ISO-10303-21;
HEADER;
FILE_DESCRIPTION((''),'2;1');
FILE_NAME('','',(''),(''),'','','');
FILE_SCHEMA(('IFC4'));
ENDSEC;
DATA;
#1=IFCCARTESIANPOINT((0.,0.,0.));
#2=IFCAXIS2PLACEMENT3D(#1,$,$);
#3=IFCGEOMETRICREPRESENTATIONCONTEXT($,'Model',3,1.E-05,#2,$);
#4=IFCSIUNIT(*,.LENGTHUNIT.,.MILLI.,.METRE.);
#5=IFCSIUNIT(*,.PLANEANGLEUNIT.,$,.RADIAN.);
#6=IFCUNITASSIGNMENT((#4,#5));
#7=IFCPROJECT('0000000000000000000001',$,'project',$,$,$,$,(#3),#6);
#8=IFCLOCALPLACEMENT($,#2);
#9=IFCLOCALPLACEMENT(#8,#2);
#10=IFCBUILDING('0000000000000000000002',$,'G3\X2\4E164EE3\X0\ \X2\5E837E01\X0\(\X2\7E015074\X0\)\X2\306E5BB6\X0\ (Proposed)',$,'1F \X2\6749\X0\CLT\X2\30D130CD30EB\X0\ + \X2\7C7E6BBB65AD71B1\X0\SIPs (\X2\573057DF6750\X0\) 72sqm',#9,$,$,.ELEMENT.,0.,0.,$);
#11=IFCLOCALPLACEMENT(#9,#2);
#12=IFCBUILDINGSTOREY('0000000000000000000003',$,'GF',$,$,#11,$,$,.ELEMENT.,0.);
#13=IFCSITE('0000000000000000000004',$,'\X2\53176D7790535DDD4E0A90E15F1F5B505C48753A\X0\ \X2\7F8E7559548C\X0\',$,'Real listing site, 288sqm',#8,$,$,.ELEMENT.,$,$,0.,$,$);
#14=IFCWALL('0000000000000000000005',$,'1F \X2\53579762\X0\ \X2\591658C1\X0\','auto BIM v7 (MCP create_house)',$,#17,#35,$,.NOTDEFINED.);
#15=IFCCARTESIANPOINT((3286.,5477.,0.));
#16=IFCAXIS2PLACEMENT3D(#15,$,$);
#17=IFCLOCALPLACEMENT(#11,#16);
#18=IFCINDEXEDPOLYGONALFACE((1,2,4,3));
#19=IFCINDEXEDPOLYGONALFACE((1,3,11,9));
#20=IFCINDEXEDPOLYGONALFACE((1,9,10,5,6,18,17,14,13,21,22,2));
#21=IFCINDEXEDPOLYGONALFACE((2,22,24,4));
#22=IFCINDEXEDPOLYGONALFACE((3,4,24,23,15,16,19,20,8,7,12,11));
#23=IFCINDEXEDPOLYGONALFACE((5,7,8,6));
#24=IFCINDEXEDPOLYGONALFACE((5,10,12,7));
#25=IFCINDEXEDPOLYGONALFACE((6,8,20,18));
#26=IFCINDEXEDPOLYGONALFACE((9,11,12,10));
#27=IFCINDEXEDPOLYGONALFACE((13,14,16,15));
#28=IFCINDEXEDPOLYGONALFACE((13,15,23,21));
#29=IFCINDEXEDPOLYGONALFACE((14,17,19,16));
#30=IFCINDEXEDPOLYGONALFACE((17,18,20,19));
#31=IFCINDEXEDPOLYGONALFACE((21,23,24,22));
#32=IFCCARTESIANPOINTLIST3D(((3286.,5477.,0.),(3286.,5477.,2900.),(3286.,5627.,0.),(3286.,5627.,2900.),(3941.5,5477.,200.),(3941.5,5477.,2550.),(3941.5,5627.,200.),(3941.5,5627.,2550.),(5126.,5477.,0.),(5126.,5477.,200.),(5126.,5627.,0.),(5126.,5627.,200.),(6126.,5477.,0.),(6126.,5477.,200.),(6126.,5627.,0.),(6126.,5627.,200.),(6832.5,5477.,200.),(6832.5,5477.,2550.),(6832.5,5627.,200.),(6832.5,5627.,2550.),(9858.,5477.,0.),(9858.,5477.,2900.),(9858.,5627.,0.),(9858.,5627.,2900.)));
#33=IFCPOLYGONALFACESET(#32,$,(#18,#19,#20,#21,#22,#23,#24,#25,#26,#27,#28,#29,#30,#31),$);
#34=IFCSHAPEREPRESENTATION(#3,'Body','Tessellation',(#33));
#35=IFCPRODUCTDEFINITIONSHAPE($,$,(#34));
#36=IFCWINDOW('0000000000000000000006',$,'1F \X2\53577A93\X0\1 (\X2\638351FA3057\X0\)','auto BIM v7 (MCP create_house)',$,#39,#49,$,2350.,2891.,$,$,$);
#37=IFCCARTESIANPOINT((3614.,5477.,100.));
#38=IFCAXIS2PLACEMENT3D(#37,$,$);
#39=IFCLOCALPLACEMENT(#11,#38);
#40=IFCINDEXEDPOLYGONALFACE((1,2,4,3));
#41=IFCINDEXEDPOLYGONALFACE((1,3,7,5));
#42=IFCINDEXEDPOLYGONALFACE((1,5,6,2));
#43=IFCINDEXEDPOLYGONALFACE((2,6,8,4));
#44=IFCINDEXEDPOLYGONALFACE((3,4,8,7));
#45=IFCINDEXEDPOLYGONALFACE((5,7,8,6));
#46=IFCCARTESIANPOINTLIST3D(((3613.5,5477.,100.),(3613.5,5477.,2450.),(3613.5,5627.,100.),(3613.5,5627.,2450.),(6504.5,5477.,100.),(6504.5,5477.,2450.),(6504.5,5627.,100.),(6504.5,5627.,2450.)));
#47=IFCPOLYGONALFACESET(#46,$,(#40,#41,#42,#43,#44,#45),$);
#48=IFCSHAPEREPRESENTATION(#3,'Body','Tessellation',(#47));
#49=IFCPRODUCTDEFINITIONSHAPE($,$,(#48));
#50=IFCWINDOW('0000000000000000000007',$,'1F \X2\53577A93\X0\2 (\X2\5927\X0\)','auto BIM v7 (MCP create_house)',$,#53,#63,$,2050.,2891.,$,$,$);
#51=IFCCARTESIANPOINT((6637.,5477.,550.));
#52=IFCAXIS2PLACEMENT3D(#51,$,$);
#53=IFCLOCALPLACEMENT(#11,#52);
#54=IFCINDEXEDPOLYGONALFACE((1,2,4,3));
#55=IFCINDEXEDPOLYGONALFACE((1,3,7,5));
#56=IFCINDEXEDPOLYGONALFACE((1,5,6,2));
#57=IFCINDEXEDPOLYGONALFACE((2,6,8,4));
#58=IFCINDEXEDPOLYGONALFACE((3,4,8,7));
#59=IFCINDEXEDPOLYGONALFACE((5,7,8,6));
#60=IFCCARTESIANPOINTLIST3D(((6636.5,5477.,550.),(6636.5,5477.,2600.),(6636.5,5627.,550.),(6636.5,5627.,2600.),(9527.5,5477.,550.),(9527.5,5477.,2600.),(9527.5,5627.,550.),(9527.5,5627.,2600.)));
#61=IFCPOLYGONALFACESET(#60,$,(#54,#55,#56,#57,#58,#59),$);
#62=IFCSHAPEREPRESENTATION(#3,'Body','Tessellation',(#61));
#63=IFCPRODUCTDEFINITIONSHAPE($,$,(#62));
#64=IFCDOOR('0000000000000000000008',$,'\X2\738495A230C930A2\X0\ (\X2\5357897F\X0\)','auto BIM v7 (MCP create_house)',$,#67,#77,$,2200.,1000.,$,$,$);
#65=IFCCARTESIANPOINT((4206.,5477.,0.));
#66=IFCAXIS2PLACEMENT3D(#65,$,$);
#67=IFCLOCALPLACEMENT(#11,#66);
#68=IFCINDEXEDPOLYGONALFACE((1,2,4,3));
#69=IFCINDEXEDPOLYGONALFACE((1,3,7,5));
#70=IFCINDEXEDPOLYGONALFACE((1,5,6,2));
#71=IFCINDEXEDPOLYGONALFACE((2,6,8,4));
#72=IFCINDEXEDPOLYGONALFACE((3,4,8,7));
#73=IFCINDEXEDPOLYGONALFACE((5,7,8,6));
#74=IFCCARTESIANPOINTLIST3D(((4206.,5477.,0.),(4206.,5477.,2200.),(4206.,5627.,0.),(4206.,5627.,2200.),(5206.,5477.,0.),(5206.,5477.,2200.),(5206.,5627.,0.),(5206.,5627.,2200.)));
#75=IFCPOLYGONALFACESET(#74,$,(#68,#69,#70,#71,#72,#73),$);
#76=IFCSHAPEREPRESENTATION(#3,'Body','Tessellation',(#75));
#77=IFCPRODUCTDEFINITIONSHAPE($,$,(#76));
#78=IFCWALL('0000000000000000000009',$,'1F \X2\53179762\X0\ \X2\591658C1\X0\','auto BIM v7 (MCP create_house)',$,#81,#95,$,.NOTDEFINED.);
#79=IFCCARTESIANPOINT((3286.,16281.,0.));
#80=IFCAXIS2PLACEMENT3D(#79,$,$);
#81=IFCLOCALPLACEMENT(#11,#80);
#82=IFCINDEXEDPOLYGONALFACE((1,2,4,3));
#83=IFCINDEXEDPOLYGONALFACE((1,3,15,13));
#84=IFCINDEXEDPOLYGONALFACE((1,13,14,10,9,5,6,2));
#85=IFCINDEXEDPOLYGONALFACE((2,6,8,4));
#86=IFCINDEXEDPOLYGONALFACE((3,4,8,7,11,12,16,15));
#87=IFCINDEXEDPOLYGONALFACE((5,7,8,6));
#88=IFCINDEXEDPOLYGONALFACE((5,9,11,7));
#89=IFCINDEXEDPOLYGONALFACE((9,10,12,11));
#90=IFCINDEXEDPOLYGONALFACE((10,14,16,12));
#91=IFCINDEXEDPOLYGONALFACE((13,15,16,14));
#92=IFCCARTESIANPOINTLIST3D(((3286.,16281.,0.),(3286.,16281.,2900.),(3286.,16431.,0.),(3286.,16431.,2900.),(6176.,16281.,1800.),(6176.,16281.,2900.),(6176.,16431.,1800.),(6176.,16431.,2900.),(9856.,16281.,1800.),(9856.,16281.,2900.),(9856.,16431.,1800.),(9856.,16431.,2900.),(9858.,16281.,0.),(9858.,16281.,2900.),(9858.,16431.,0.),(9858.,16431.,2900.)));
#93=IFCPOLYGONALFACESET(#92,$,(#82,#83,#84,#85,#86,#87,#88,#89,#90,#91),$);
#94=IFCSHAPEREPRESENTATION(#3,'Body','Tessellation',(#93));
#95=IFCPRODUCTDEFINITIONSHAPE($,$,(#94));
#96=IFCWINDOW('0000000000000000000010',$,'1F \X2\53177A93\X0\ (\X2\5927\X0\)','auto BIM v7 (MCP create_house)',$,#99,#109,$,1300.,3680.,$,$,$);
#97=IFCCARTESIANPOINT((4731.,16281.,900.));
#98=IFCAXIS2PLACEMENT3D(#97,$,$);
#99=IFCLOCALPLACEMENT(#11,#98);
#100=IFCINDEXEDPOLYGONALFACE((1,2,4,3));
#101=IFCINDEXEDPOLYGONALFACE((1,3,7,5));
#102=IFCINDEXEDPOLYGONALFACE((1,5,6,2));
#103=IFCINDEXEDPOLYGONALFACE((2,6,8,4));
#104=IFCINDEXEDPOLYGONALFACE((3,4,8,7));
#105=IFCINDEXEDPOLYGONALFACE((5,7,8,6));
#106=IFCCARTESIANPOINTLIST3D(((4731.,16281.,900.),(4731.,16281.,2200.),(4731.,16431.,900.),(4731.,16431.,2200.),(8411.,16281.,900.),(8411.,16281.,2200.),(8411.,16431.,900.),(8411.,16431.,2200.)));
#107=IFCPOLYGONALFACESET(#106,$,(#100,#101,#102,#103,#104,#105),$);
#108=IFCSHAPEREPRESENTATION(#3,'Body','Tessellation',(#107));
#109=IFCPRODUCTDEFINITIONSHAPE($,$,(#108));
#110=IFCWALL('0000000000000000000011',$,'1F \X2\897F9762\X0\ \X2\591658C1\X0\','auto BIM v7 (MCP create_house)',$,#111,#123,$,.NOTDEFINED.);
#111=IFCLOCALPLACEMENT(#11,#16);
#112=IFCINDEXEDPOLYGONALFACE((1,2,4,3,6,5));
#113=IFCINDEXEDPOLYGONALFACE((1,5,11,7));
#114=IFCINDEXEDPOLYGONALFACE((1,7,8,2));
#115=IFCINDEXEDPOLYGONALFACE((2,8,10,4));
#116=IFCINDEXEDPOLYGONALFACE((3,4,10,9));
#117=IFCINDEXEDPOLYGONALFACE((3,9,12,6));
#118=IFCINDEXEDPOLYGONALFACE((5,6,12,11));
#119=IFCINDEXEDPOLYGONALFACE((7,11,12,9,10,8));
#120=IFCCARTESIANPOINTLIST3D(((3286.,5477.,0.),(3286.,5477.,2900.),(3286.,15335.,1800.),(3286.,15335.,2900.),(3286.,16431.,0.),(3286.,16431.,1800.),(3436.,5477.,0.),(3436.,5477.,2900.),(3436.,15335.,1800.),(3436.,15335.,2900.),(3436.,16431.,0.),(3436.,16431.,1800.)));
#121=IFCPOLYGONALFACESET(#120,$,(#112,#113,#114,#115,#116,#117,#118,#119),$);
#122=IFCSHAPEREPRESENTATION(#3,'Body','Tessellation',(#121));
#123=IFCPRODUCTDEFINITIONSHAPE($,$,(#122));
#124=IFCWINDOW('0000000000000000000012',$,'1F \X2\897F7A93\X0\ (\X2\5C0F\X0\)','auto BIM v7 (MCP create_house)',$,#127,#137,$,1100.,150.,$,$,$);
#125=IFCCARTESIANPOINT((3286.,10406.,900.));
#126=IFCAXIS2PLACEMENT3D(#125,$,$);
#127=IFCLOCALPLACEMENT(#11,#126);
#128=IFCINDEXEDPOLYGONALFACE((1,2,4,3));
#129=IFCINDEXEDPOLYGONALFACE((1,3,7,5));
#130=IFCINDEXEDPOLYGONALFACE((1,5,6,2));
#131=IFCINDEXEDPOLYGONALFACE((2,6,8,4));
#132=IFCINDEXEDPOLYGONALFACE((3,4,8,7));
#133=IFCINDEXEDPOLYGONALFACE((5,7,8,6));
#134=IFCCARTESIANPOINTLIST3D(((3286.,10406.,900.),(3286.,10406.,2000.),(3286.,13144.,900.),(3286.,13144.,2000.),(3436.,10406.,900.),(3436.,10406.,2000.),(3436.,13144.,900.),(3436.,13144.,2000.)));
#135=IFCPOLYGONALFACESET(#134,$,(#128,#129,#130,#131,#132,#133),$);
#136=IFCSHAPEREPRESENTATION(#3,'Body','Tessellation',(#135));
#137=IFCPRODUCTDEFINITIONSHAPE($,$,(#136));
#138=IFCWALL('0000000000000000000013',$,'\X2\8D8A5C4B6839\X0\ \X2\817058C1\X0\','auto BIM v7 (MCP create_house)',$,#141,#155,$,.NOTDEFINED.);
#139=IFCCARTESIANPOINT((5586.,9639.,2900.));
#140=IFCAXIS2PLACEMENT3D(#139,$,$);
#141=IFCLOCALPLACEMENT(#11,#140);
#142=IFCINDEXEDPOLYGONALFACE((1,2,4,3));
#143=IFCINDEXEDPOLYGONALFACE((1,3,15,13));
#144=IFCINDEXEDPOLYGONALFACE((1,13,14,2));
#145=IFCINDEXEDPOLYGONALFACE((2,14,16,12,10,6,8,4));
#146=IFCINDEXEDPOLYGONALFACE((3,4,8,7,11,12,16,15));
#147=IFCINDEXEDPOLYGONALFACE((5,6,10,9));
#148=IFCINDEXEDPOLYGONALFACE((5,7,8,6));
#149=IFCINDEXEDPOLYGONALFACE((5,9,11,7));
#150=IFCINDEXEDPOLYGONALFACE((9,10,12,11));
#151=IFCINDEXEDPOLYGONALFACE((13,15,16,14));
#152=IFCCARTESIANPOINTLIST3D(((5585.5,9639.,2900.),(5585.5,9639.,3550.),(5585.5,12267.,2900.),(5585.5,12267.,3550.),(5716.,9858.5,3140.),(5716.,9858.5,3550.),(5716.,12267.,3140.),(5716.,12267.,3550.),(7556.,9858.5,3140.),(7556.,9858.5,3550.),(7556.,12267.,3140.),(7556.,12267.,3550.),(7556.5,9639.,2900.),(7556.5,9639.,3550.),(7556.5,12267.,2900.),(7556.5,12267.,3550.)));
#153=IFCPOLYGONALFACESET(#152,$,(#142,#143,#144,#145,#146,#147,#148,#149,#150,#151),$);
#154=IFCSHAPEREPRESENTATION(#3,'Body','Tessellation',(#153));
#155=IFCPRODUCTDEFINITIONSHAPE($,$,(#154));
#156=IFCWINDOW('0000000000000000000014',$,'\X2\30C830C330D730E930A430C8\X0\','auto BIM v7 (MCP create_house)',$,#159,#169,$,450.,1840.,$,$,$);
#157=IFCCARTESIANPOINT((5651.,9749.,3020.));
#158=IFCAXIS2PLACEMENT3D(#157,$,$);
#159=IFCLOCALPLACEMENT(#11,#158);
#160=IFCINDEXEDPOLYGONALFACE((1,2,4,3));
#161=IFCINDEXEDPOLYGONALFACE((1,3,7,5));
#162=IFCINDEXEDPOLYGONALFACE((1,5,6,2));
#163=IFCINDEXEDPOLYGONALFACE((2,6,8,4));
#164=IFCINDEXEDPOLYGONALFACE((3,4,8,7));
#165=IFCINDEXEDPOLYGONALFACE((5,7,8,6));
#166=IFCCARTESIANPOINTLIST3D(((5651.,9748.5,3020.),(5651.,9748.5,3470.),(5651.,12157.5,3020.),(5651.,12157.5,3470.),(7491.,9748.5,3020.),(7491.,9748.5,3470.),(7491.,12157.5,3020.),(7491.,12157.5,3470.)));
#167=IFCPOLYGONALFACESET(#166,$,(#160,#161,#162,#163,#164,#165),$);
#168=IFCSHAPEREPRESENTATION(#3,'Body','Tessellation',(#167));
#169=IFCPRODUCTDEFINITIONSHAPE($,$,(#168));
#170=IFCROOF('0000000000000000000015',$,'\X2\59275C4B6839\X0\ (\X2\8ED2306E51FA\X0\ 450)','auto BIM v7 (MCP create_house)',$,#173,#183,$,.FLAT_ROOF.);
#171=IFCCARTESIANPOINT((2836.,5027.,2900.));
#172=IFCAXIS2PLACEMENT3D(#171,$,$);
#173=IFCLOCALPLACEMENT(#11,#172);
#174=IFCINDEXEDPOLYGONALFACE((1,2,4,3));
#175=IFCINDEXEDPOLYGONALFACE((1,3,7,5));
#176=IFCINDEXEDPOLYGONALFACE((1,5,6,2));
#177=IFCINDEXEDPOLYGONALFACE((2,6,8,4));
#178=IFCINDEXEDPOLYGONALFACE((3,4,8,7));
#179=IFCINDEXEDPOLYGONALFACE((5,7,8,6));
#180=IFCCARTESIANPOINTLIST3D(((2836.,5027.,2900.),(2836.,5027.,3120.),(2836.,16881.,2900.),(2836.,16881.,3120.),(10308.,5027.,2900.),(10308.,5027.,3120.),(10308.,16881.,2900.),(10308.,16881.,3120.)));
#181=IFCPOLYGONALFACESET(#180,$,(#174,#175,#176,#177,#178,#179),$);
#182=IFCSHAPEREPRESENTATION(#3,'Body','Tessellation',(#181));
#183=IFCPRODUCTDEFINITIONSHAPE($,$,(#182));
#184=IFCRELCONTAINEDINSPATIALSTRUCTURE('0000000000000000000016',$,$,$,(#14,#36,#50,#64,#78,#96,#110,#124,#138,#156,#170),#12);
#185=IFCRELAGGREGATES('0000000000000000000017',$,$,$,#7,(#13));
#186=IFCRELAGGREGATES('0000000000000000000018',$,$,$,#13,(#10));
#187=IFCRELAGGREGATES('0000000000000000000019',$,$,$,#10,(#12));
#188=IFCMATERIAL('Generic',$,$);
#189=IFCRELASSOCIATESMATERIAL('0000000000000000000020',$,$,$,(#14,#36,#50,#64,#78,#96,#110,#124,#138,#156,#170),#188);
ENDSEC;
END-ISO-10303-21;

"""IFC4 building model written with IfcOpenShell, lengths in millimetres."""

from ifc_helpers import new_model, si_unit, frame, frame_2d, origin, place, context, project, spatial, rectangle, extrude, material, element, fill, save


model = new_model("IFC4")

# Units and contexts
model_context = context("Model", 3, precision=1e-05, world=origin())
ifc_project = project(units=[si_unit("LENGTHUNIT", "METRE", prefix="MILLI"), si_unit("PLANEANGLEUNIT", "RADIAN")], contexts=[model_context])

# Site, building, storey
site_placement = place(None, origin())
site = spatial("IfcSite", under=ifc_project, at=site_placement, Name="北海道川上郡弟子屈町 美留和", ObjectType="Real listing site, 288sqm", CompositionType="ELEMENT", RefElevation=0.0)
building_placement = place(site_placement, origin())
building = spatial("IfcBuilding", under=site, at=building_placement, Name="G3世代 広縁(縁側)の家 (Proposed)", ObjectType="1F 杉CLTパネル + 籾殻断熱SIPs (地域材) 72sqm", CompositionType="ELEMENT", ElevationOfRefHeight=0.0, ElevationOfTerrain=0.0)
storey_placement = place(building_placement, origin())
storey = spatial("IfcBuildingStorey", under=building, at=storey_placement, Name="GF", CompositionType="ELEMENT", Elevation=0.0)

# Shared definitions
ifc_material = material(Name="Generic")

# Wall, openings, windows, door
wall_1_placement = place(storey_placement, frame((3286.0, 5477.0, 0.0)))
wall_1 = element("IfcWall", 1, at=wall_1_placement, inside=storey, material=ifc_material, Name="1F 南面 外壁", Description="auto BIM v7 (MCP create_house)", PredefinedType="NOTDEFINED", context=model_context, shape_type="SweptSolid", body=[
    extrude(rectangle(XDim=6572.0, YDim=150.0, at=frame_2d((3286.0, 75.0))), frame((3286.0, 5477.0, 0.0)), (0.0, 0.0, 1.0), 2900.0),
])
opening_1_placement = place(storey_placement, frame((3614.0, 5477.0, 100.0)))
opening_1 = element("IfcOpeningElement", 2, at=opening_1_placement, cuts=wall_1, PredefinedType="NOTDEFINED", context=model_context, shape_type="SweptSolid", body=[
    extrude(rectangle(XDim=2891.0, YDim=150.0, at=frame_2d((1445.0, 75.0))), frame((3614.0, 5477.0, 100.0)), (0.0, 0.0, 1.0), 2350.0),
])
opening_2_placement = place(storey_placement, frame((6637.0, 5477.0, 550.0)))
opening_2 = element("IfcOpeningElement", 3, at=opening_2_placement, cuts=wall_1, PredefinedType="NOTDEFINED", context=model_context, shape_type="SweptSolid", body=[
    extrude(rectangle(XDim=2891.0, YDim=150.0, at=frame_2d((1445.0, 75.0))), frame((6637.0, 5477.0, 550.0)), (0.0, 0.0, 1.0), 2050.0),
])
opening_3_placement = place(storey_placement, frame((4206.0, 5477.0, 0.0)))
opening_3 = element("IfcOpeningElement", 4, at=opening_3_placement, cuts=wall_1, PredefinedType="NOTDEFINED", context=model_context, shape_type="SweptSolid", body=[
    extrude(rectangle(XDim=1000.0, YDim=150.0, at=frame_2d((500.0, 75.0))), frame((4206.0, 5477.0, 0.0)), (0.0, 0.0, 1.0), 2200.0),
])
window_1_placement = place(storey_placement, frame((3614.0, 5477.0, 100.0)))
window_1 = element("IfcWindow", 5, at=window_1_placement, inside=storey, material=ifc_material, Name="1F 南窓1 (掃出し)", Description="auto BIM v7 (MCP create_house)", OverallHeight=2350.0, OverallWidth=2891.0, context=model_context, shape_type="SweptSolid", body=[
    extrude(rectangle(XDim=2891.0, YDim=150.0, at=frame_2d((1445.0, 75.0))), frame((3614.0, 5477.0, 100.0)), (0.0, 0.0, 1.0), 2350.0),
])
fill(opening_1, window_1)
window_2_placement = place(storey_placement, frame((6637.0, 5477.0, 550.0)))
window_2 = element("IfcWindow", 6, at=window_2_placement, inside=storey, material=ifc_material, Name="1F 南窓2 (大)", Description="auto BIM v7 (MCP create_house)", OverallHeight=2050.0, OverallWidth=2891.0, context=model_context, shape_type="SweptSolid", body=[
    extrude(rectangle(XDim=2891.0, YDim=150.0, at=frame_2d((1445.0, 75.0))), frame((6637.0, 5477.0, 550.0)), (0.0, 0.0, 1.0), 2050.0),
])
fill(opening_2, window_2)
door_placement = place(storey_placement, frame((4206.0, 5477.0, 0.0)))
door = element("IfcDoor", 7, at=door_placement, inside=storey, material=ifc_material, Name="玄関ドア (南西)", Description="auto BIM v7 (MCP create_house)", OverallHeight=2200.0, OverallWidth=1000.0, context=model_context, shape_type="SweptSolid", body=[
    extrude(rectangle(XDim=1000.0, YDim=150.0, at=frame_2d((500.0, 75.0))), frame((4206.0, 5477.0, 0.0)), (0.0, 0.0, 1.0), 2200.0),
])
fill(opening_3, door)

# Walls, openings, windows
wall_2_placement = place(storey_placement, frame((3286.0, 16281.0, 0.0)))
wall_2 = element("IfcWall", 8, at=wall_2_placement, inside=storey, material=ifc_material, Name="1F 北面 外壁", Description="auto BIM v7 (MCP create_house)", PredefinedType="NOTDEFINED", context=model_context, shape_type="SweptSolid", body=[
    extrude(rectangle(XDim=6572.0, YDim=150.0, at=frame_2d((3286.0, 75.0))), frame((3286.0, 16281.0, 0.0)), (0.0, 0.0, 1.0), 2900.0),
])
opening_4_placement = place(storey_placement, frame((4731.0, 16281.0, 900.0)))
opening_4 = element("IfcOpeningElement", 9, at=opening_4_placement, cuts=wall_2, PredefinedType="NOTDEFINED", context=model_context, shape_type="SweptSolid", body=[
    extrude(rectangle(XDim=3680.0, YDim=150.0, at=frame_2d((1840.0, 75.0))), frame((4731.0, 16281.0, 900.0)), (0.0, 0.0, 1.0), 1300.0),
])
window_3_placement = place(storey_placement, frame((4731.0, 16281.0, 900.0)))
window_3 = element("IfcWindow", 10, at=window_3_placement, inside=storey, material=ifc_material, Name="1F 北窓 (大)", Description="auto BIM v7 (MCP create_house)", OverallHeight=1300.0, OverallWidth=3680.0, context=model_context, shape_type="SweptSolid", body=[
    extrude(rectangle(XDim=3680.0, YDim=150.0, at=frame_2d((1840.0, 75.0))), frame((4731.0, 16281.0, 900.0)), (0.0, 0.0, 1.0), 1300.0),
])
fill(opening_4, window_3)
wall_3_placement = place(storey_placement, frame((3286.0, 5477.0, 0.0)))
wall_3 = element("IfcWall", 11, at=wall_3_placement, inside=storey, material=ifc_material, Name="1F 西面 外壁", Description="auto BIM v7 (MCP create_house)", PredefinedType="NOTDEFINED", context=model_context, shape_type="SweptSolid", body=[
    extrude(rectangle(XDim=150.0, YDim=10954.0, at=frame_2d((75.0, 5477.0))), frame((3286.0, 5477.0, 0.0)), (0.0, 0.0, 1.0), 2900.0),
])
opening_5_placement = place(storey_placement, frame((3286.0, 10406.0, 900.0)))
opening_5 = element("IfcOpeningElement", 12, at=opening_5_placement, cuts=wall_3, PredefinedType="NOTDEFINED", context=model_context, shape_type="SweptSolid", body=[
    extrude(rectangle(XDim=150.0, YDim=2738.0, at=frame_2d((75.0, 1369.0))), frame((3286.0, 10406.0, 900.0)), (0.0, 0.0, 1.0), 1100.0),
])
window_4_placement = place(storey_placement, frame((3286.0, 10406.0, 900.0)))
window_4 = element("IfcWindow", 13, at=window_4_placement, inside=storey, material=ifc_material, Name="1F 西窓 (小)", Description="auto BIM v7 (MCP create_house)", OverallHeight=1100.0, OverallWidth=150.0, context=model_context, shape_type="SweptSolid", body=[
    extrude(rectangle(XDim=150.0, YDim=2738.0, at=frame_2d((75.0, 1369.0))), frame((3286.0, 10406.0, 900.0)), (0.0, 0.0, 1.0), 1100.0),
])
fill(opening_5, window_4)

# Wall, opening, window
wall_4_placement = place(storey_placement, frame((5586.0, 9639.0, 2900.0)))
wall_4 = element("IfcWall", 14, at=wall_4_placement, inside=storey, material=ifc_material, Name="越屋根 腰壁", Description="auto BIM v7 (MCP create_house)", PredefinedType="NOTDEFINED", context=model_context, shape_type="SweptSolid", body=[
    extrude(rectangle(XDim=1971.0, YDim=2628.0, at=frame_2d((985.0, 1314.0))), frame((5586.0, 9639.0, 2900.0)), (0.0, 0.0, 1.0), 650.0),
])
opening_6_placement = place(storey_placement, frame((5651.0, 9749.0, 3020.0)))
opening_6 = element("IfcOpeningElement", 15, at=opening_6_placement, cuts=wall_4, PredefinedType="NOTDEFINED", context=model_context, shape_type="SweptSolid", body=[
    extrude(rectangle(XDim=1840.0, YDim=2409.0, at=frame_2d((920.0, 1204.0))), frame((5651.0, 9749.0, 3020.0)), (0.0, 0.0, 1.0), 450.0),
])
window_5_placement = place(storey_placement, frame((5651.0, 9749.0, 3020.0)))
window_5 = element("IfcWindow", 16, at=window_5_placement, inside=storey, material=ifc_material, Name="トップライト", Description="auto BIM v7 (MCP create_house)", OverallHeight=450.0, OverallWidth=1840.0, context=model_context, shape_type="SweptSolid", body=[
    extrude(rectangle(XDim=1840.0, YDim=2409.0, at=frame_2d((920.0, 1204.0))), frame((5651.0, 9749.0, 3020.0)), (0.0, 0.0, 1.0), 450.0),
])
fill(opening_6, window_5)

# Roof
roof_1_placement = place(storey_placement, frame((2836.0, 5027.0, 2900.0)))
element("IfcRoof", 17, at=roof_1_placement, inside=storey, material=ifc_material, Name="大屋根 (軒の出 450)", Description="auto BIM v7 (MCP create_house)", PredefinedType="FLAT_ROOF", context=model_context, shape_type="SweptSolid", body=[
    extrude(rectangle(XDim=7472.0, YDim=11854.0, at=frame_2d((3736.0, 5927.0))), frame((2836.0, 5027.0, 2900.0)), (0.0, 0.0, 1.0), 220.0),
])

save(model, "model.ifc")
